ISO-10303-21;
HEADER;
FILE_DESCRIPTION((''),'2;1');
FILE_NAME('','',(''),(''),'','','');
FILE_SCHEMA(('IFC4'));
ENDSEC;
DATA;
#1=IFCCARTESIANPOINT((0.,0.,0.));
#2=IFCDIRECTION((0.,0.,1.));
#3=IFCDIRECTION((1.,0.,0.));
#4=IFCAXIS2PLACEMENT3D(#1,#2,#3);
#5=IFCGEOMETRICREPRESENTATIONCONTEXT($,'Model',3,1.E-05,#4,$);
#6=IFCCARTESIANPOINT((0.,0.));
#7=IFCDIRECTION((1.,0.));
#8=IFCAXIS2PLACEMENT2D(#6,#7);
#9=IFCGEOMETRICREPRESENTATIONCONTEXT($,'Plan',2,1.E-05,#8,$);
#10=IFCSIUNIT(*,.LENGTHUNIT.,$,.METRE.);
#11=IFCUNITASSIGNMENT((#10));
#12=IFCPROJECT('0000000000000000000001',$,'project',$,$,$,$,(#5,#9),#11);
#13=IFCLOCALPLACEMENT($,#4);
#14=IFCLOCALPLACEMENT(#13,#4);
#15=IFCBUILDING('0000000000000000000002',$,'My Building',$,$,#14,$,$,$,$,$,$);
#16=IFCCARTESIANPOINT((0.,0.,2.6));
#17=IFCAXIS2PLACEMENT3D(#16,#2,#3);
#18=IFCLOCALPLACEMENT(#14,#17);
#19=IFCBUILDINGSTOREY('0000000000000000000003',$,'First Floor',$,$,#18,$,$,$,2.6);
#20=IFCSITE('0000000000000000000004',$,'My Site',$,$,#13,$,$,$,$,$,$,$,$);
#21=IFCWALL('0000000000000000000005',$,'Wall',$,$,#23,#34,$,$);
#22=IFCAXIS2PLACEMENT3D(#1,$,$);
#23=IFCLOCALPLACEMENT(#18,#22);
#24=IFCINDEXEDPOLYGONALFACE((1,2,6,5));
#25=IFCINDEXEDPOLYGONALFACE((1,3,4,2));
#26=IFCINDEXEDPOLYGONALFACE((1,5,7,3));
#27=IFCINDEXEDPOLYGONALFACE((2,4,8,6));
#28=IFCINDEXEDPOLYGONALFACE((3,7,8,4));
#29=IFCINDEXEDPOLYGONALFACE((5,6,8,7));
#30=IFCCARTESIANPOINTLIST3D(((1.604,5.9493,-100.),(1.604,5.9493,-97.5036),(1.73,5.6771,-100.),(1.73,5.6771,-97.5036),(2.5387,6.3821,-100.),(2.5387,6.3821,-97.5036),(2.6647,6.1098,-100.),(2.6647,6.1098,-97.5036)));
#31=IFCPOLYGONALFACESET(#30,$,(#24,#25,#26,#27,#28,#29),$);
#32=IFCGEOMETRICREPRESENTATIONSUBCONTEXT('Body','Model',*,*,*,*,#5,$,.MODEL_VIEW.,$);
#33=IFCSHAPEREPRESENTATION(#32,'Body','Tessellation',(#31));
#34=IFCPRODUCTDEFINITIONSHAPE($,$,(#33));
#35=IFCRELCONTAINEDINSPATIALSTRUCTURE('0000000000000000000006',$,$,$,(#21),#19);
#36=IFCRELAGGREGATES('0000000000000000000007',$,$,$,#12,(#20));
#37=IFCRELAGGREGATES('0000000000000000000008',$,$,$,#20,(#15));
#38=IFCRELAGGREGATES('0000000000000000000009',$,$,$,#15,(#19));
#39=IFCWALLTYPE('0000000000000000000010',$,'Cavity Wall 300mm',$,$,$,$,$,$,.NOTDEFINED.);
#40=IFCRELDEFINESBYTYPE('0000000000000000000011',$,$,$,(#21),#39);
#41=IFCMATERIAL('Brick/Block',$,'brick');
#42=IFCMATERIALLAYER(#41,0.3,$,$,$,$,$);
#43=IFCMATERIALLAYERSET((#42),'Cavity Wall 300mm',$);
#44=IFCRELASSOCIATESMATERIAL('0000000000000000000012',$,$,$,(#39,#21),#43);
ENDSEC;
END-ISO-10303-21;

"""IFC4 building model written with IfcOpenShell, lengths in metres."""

from ifc_helpers import new_model, si_unit, frame, origin_with_axes, origin_2d_with_axis, place, context, subcontext, project, spatial, indexed_curve, outline, extrude, material, layer, layer_set, layer_usage, type_object, element, save


model = new_model("IFC4")

# Units and contexts
model_context = context("Model", 3, precision=1e-05, world=origin_with_axes())
plan_context = context("Plan", 2, precision=1e-05, world=origin_2d_with_axis())
body_context = subcontext(model_context, "Body", "Model", "MODEL_VIEW")
ifc_project = project(units=[si_unit("LENGTHUNIT", "METRE")], contexts=[model_context, plan_context])

# Site, building, storey
site_placement = place(None, origin_with_axes())
site = spatial("IfcSite", under=ifc_project, at=site_placement, Name="My Site")
building_placement = place(site_placement, origin_with_axes())
building = spatial("IfcBuilding", under=site, at=building_placement, Name="My Building")
storey_placement = place(building_placement, frame((0.0, 0.0, 2.6), z_axis=(0.0, 0.0, 1.0), x_axis=(1.0, 0.0, 0.0)))
storey = spatial("IfcBuildingStorey", under=building, at=storey_placement, Name="First Floor", Elevation=2.6)

# Wall
ifc_material = material(Name="Brick/Block", Category="brick")
ifc_layer = layer(ifc_material, 0.3)
ifc_layer_set = layer_set([ifc_layer], Name="Cavity Wall 300mm")
ifc_layer_usage = layer_usage(ifc_layer_set, "AXIS2", "POSITIVE", 0.0)
wall_type = type_object("IfcWallType", Name="Cavity Wall 300mm", PredefinedType="NOTDEFINED", material=ifc_layer_set)
wall_placement = place(storey_placement, frame((1.73, 5.6771, -100.0), z_axis=(0.0, 0.0, 1.0), x_axis=(0.907469, 0.420118, 0.0)))
element("IfcWall", 1, at=wall_placement, inside=storey, type_object=wall_type, material=ifc_layer_usage, Name="Wall", context=body_context, shape_type="SweptSolid", body=[
    extrude(outline(indexed_curve([(0.0, 0.0), (0.0, 0.3), (1.03, 0.3), (1.03, 0.0), (0.0, 0.0)], self_intersect=False)), origin_with_axes(), (0.0, 0.0, 1.0), 2.4964),
])

save(model, "model.ifc")
